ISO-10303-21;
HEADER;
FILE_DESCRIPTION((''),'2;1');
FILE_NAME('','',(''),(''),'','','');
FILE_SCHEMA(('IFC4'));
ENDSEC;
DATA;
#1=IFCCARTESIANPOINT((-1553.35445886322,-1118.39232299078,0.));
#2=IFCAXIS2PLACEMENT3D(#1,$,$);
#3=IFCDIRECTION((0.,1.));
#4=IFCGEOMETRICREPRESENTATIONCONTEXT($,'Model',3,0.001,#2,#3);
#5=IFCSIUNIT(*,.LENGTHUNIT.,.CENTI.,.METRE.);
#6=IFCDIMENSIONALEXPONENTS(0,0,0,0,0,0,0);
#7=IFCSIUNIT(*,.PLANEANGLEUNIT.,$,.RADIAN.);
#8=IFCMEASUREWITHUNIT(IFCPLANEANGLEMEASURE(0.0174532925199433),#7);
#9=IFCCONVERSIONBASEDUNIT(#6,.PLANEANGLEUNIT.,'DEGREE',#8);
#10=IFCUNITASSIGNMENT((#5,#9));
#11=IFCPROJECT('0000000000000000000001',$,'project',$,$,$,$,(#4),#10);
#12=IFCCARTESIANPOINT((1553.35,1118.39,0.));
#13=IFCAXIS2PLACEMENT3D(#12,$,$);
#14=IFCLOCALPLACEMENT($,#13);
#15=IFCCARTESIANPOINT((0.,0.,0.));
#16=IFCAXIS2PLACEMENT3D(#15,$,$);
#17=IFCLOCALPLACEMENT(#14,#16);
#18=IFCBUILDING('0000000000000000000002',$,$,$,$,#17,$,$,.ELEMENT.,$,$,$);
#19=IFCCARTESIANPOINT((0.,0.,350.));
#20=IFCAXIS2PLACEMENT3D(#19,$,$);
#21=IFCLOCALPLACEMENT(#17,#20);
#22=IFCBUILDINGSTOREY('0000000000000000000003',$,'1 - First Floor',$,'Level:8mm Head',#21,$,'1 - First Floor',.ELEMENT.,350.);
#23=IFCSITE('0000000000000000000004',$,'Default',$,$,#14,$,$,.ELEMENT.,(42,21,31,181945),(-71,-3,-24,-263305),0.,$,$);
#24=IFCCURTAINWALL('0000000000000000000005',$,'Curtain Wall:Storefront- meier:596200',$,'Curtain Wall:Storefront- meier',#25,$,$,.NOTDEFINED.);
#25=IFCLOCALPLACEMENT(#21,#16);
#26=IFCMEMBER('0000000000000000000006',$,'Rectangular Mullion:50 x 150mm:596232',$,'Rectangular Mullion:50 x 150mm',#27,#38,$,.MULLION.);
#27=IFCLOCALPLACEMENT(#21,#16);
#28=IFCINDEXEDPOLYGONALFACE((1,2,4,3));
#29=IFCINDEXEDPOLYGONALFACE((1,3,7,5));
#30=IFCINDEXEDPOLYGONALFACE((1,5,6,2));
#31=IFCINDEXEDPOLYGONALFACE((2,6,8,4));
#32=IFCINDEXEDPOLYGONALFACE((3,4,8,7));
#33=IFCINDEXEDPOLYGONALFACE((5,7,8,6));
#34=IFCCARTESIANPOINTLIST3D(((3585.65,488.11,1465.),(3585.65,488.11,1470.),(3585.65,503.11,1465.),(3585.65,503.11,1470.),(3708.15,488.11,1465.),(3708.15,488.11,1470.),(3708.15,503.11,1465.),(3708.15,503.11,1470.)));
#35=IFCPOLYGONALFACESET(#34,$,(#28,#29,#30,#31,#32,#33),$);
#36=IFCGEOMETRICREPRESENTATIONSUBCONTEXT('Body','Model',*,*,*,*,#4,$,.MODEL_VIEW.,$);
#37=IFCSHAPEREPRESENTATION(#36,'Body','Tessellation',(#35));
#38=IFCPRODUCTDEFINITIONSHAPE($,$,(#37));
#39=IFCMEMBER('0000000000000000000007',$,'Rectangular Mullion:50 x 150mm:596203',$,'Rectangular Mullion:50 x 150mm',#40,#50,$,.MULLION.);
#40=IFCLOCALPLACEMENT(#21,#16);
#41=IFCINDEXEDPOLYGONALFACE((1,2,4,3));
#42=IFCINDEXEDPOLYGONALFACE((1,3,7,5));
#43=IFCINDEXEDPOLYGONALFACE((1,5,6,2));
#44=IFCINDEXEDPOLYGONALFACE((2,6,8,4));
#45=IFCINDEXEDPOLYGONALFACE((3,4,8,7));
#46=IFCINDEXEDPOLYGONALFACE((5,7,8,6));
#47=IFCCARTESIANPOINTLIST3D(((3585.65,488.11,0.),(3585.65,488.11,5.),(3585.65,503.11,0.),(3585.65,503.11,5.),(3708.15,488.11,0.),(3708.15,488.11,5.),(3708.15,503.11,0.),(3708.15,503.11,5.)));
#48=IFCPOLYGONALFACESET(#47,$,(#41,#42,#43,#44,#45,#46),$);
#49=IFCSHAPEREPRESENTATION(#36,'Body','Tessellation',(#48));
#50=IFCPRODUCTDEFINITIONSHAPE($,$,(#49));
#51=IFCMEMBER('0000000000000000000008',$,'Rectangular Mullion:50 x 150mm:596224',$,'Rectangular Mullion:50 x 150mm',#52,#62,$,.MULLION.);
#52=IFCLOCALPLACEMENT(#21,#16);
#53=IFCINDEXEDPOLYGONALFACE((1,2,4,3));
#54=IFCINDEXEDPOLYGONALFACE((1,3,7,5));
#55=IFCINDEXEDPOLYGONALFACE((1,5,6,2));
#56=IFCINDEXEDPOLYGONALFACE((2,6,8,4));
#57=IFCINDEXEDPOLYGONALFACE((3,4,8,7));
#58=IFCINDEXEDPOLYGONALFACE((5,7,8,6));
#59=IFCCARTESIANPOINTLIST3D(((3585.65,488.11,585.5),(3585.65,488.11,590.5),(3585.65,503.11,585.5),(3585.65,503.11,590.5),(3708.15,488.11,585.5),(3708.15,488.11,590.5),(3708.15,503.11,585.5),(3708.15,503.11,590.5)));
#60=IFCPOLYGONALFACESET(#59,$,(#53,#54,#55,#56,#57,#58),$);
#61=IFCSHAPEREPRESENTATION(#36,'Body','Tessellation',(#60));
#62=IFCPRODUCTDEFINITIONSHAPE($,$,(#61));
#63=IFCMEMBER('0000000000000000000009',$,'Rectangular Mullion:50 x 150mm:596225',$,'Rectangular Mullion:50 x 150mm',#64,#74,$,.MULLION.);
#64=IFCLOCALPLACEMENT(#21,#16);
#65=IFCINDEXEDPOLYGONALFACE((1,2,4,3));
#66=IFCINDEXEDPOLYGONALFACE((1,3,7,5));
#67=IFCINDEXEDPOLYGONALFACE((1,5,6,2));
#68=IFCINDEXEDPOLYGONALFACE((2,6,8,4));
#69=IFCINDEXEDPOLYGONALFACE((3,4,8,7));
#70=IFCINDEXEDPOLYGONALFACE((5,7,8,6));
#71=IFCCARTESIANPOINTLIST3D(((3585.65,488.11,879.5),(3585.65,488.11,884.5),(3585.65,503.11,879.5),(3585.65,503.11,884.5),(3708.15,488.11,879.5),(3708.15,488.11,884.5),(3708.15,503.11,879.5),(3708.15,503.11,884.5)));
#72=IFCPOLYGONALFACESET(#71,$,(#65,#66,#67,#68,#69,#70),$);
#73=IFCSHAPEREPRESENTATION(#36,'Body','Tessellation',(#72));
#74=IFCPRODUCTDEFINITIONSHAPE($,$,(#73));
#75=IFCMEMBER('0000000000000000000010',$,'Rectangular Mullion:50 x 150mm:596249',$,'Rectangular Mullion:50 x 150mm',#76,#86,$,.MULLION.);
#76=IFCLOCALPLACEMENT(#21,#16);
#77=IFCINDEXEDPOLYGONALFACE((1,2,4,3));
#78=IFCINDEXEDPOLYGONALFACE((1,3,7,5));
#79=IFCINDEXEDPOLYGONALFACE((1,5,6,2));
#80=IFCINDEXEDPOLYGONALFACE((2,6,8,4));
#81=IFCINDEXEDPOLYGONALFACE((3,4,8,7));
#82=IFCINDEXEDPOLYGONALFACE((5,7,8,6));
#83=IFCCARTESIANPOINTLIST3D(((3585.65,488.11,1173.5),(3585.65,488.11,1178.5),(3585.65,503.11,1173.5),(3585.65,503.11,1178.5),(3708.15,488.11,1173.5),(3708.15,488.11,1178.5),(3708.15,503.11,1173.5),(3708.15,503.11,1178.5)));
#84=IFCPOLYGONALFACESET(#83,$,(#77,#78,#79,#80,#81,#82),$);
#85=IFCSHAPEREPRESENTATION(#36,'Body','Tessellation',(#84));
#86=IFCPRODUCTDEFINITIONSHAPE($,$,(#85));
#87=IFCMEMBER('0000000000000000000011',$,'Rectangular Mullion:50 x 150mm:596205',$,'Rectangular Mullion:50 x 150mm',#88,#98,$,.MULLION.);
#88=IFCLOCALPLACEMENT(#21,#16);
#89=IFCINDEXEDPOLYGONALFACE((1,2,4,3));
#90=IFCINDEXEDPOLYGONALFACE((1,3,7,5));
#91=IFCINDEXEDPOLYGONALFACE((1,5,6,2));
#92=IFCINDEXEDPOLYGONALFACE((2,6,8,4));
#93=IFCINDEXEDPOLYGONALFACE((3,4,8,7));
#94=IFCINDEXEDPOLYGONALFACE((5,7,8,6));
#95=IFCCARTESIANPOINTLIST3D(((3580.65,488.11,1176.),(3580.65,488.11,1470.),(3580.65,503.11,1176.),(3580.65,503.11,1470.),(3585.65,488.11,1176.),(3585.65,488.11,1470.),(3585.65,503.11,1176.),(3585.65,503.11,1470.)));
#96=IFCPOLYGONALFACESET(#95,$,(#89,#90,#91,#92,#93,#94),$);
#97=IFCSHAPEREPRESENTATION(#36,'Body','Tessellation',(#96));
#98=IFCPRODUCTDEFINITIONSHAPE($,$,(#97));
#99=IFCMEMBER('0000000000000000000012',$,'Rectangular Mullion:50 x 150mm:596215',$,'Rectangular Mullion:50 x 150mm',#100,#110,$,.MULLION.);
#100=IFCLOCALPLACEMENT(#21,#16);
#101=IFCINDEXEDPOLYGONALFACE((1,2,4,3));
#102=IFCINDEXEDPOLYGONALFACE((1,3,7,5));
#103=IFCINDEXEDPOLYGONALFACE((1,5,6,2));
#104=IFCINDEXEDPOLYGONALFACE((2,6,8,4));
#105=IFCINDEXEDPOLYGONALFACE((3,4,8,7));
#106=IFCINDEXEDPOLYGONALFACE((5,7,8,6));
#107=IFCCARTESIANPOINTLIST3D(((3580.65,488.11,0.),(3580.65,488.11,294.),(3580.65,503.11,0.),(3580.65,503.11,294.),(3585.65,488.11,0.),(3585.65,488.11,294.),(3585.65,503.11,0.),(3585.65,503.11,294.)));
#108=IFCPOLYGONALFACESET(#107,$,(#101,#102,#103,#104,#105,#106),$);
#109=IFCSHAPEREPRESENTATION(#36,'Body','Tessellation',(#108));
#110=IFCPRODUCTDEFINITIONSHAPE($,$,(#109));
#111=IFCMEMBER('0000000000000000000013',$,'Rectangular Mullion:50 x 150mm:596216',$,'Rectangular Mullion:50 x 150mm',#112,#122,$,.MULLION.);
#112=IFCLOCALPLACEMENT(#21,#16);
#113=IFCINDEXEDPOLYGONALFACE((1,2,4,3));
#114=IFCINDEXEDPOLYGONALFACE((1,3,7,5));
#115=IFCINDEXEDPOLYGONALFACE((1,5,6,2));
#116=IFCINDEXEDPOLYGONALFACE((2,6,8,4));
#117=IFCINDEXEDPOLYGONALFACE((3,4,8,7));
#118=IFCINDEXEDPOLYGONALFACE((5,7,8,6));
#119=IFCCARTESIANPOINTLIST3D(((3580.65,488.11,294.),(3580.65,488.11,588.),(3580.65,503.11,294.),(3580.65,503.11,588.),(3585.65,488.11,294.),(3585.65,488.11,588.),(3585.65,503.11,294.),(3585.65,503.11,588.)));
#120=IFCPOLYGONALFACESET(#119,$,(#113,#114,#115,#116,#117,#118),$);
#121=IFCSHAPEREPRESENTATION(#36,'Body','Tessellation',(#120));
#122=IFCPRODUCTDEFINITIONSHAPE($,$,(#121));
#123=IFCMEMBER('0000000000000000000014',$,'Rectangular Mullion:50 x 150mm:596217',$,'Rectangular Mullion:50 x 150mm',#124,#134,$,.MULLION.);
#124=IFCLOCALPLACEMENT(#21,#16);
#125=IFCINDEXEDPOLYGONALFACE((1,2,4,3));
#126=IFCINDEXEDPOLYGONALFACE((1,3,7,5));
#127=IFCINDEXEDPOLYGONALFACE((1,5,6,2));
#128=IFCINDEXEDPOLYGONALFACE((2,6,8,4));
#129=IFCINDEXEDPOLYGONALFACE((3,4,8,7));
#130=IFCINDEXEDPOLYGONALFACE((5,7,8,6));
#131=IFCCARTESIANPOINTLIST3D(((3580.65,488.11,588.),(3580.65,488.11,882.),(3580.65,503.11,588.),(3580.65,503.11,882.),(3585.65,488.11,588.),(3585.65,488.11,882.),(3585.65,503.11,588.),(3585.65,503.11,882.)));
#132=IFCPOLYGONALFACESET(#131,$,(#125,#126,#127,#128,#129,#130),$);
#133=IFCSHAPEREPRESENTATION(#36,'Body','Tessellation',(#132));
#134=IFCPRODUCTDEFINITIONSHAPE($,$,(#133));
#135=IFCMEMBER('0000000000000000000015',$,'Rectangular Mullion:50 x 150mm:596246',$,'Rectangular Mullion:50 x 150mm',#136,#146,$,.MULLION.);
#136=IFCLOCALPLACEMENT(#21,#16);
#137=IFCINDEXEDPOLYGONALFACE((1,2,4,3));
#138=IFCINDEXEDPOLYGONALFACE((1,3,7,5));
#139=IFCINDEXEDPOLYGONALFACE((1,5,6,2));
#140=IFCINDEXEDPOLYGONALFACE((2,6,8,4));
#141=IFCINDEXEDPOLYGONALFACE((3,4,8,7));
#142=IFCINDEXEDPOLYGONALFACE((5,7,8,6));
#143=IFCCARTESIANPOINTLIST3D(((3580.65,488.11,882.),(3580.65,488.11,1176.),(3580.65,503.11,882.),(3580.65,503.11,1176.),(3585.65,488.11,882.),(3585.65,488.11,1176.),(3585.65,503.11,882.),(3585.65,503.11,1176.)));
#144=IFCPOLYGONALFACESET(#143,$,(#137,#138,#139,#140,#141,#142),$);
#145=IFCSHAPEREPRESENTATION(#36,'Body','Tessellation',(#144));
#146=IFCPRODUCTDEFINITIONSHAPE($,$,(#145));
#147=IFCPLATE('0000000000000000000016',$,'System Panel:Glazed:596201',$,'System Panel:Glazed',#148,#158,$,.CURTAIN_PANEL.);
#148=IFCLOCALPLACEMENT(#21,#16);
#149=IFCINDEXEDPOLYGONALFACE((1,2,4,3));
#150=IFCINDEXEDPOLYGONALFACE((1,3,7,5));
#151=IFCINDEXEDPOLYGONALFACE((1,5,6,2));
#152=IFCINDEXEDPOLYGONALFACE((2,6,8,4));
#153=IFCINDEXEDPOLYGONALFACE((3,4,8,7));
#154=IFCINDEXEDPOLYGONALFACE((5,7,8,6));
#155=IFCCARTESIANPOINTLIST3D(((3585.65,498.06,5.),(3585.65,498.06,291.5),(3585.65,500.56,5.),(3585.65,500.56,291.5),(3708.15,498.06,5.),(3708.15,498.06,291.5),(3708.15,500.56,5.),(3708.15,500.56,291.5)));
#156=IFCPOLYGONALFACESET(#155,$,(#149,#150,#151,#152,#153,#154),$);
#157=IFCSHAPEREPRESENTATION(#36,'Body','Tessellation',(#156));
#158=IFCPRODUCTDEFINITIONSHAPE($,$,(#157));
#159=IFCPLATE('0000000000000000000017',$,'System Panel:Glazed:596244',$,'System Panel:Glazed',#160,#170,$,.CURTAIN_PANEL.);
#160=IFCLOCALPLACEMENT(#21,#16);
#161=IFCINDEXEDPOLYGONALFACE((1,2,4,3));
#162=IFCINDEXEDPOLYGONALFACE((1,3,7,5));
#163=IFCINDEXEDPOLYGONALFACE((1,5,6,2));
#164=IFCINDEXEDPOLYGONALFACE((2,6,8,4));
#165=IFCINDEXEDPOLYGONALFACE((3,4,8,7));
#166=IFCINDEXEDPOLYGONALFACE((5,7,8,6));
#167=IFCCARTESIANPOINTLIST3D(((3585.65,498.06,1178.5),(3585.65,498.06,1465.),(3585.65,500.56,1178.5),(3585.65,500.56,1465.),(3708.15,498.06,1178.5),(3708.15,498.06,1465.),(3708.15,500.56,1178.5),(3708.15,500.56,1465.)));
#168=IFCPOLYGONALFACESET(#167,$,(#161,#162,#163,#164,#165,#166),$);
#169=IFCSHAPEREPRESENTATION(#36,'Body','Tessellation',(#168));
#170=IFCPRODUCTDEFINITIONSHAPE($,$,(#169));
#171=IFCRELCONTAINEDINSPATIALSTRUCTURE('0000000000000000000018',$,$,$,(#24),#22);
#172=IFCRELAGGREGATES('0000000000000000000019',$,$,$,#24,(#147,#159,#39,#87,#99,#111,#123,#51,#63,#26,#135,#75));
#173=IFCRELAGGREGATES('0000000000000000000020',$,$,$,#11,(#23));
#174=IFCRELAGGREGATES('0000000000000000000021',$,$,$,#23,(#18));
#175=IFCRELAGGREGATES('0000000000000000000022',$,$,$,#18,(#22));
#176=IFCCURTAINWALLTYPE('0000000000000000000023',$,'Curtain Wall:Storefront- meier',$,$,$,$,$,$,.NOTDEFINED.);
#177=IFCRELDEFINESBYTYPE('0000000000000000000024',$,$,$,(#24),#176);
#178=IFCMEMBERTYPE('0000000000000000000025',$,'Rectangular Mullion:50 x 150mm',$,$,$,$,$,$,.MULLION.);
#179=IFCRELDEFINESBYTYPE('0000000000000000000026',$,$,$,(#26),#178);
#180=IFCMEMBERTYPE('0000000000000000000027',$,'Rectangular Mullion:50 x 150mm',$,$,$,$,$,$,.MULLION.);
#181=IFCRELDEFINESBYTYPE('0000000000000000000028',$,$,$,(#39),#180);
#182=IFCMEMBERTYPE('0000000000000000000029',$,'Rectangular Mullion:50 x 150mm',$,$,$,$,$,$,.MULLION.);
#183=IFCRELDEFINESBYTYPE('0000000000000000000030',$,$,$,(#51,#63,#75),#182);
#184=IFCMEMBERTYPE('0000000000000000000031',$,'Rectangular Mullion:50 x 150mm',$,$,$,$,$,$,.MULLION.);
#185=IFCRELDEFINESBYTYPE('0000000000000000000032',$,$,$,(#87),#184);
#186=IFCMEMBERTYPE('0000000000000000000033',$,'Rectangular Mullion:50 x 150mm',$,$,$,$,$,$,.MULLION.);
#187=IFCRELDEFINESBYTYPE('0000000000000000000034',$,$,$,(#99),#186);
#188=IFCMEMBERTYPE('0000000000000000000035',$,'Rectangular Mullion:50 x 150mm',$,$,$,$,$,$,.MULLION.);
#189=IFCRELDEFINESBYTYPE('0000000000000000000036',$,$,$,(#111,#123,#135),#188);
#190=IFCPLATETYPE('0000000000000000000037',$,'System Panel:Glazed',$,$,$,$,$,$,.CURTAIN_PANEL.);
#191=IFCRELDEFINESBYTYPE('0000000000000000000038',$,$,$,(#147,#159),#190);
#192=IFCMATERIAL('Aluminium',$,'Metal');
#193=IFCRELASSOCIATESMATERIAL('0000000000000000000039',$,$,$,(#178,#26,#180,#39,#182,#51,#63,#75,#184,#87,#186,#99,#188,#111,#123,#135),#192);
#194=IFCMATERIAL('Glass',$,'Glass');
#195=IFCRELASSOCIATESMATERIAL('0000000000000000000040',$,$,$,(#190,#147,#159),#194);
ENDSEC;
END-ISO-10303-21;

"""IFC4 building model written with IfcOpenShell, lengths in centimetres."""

from ifc_helpers import new_model, entity, si_unit, converted_unit, direction, frame, origin, place, context, subcontext, project, spatial, indexed_curve, outline, extrude, source, transform, mapped, material, type_object, type_shapes, element, aggregate, save


model = new_model("IFC4")

# Units and contexts
model_context = context("Model", 3, precision=0.001, world=frame((-1553.35445886322, -1118.39232299078, 0.0)), true_north=direction((0.0, 1.0)))
body_context = subcontext(model_context, "Body", "Model", "MODEL_VIEW")
ifc_project = project(units=[si_unit("LENGTHUNIT", "METRE", prefix="CENTI"), converted_unit("PLANEANGLEUNIT", "DEGREE", entity("IfcPlaneAngleMeasure", 0.0174532925199433), si_unit("PLANEANGLEUNIT", "RADIAN"), dimensions=[0, 0, 0, 0, 0, 0, 0])], contexts=[model_context])

# Site, building, storey
site_placement = place(None, frame((1553.35, 1118.39, 0.0)))
site = spatial("IfcSite", under=ifc_project, at=site_placement, Name="Default", CompositionType="ELEMENT", RefLatitude=(42, 21, 31, 181945), RefLongitude=(-71, -3, -24, -263305), RefElevation=0.0)
building_placement = place(site_placement, origin())
building = spatial("IfcBuilding", under=site, at=building_placement, CompositionType="ELEMENT")
storey_placement = place(building_placement, frame((0.0, 0.0, 350.0)))
storey = spatial("IfcBuildingStorey", under=building, at=storey_placement, Name="1 - First Floor", ObjectType="Level:8mm Head", LongName="1 - First Floor", CompositionType="ELEMENT", Elevation=350.0)

# Curtain wall, members, plates
curtain_wall_type = type_object("IfcCurtainWallType", Name="Curtain Wall:Storefront- meier", PredefinedType="NOTDEFINED")
curtain_wall_placement = place(storey_placement, frame((0.0, 0.0, -350.0)))
curtain_wall = element("IfcCurtainWall", 1, at=curtain_wall_placement, inside=storey, type_object=curtain_wall_type, Name="Curtain Wall:Storefront- meier:596200", ObjectType="Curtain Wall:Storefront- meier", PredefinedType="NOTDEFINED")
ifc_material_1 = material(Name="Aluminium", Category="Metal")
member_type_1 = type_object("IfcMemberType", Name="Rectangular Mullion:50 x 150mm", PredefinedType="MULLION", material=ifc_material_1)
shared_shape_1 = source(origin(), body_context, "Body", "SweptSolid", [
    extrude(outline(indexed_curve([(-2.5, -7.5), (2.5, -7.5), (2.5, 7.5), (-2.5, 7.5), (-2.5, -7.5)], self_intersect=False)), frame((-2.5, 0.0, -122.5), z_axis=(0.0, 0.0, 1.0), x_axis=(-1.0, 0.0, 0.0)), (0.0, 0.0, 1.0), 122.5),
])
type_shapes(member_type_1, [shared_shape_1])
member_1_placement = place(curtain_wall_placement, frame((3708.15, 495.61, 1820.0), z_axis=(1.0, 0.0, 0.0), x_axis=(0.0, 0.0, 1.0)))
member_1 = element("IfcMember", 2, at=member_1_placement, type_object=member_type_1, material=ifc_material_1, Name="Rectangular Mullion:50 x 150mm:596232", ObjectType="Rectangular Mullion:50 x 150mm", PredefinedType="MULLION", context=body_context, shape_type="MappedRepresentation", body=[
    mapped(shared_shape_1, transform((0.0, 0.0, 0.0), scale=1.0)),
])
member_type_2 = type_object("IfcMemberType", Name="Rectangular Mullion:50 x 150mm", PredefinedType="MULLION", material=ifc_material_1)
shared_shape_2 = source(origin(), body_context, "Body", "SweptSolid", [
    extrude(outline(indexed_curve([(-2.5, -7.5), (2.5, -7.5), (2.5, 7.5), (-2.5, 7.5), (-2.5, -7.5)], self_intersect=False)), frame((-2.5, 0.0, -122.5), z_axis=(0.0, 0.0, 1.0), x_axis=(-1.0, 0.0, 0.0)), (0.0, 0.0, 1.0), 122.5),
])
type_shapes(member_type_2, [shared_shape_2])
member_2_placement = place(curtain_wall_placement, frame((3585.65, 495.61, 350.0), z_axis=(-1.0, 0.0, 0.0), x_axis=(0.0, 0.0, -1.0)))
member_2 = element("IfcMember", 3, at=member_2_placement, type_object=member_type_2, material=ifc_material_1, Name="Rectangular Mullion:50 x 150mm:596203", ObjectType="Rectangular Mullion:50 x 150mm", PredefinedType="MULLION", context=body_context, shape_type="MappedRepresentation", body=[
    mapped(shared_shape_2, transform((0.0, 0.0, 0.0), scale=1.0)),
])
member_type_3 = type_object("IfcMemberType", Name="Rectangular Mullion:50 x 150mm", PredefinedType="MULLION", material=ifc_material_1)
shared_shape_3 = source(origin(), body_context, "Body", "SweptSolid", [
    extrude(outline(indexed_curve([(-2.5, -7.5), (2.5, -7.5), (2.5, 7.5), (-2.5, 7.5), (-2.5, -7.5)], self_intersect=False)), frame((0.0, 0.0, -122.5), z_axis=(0.0, 0.0, 1.0), x_axis=(-1.0, 0.0, 0.0)), (0.0, 0.0, 1.0), 122.5),
])
type_shapes(member_type_3, [shared_shape_3])
member_3_placement = place(curtain_wall_placement, frame((3708.15, 495.61, 938.0), z_axis=(1.0, 0.0, 0.0), x_axis=(0.0, 0.0, 1.0)))
member_3 = element("IfcMember", 4, at=member_3_placement, type_object=member_type_3, material=ifc_material_1, Name="Rectangular Mullion:50 x 150mm:596224", ObjectType="Rectangular Mullion:50 x 150mm", PredefinedType="MULLION", context=body_context, shape_type="MappedRepresentation", body=[
    mapped(shared_shape_3, transform((0.0, 0.0, 0.0), scale=1.0)),
])
member_4_placement = place(curtain_wall_placement, frame((3708.15, 495.61, 1232.0), z_axis=(1.0, 0.0, 0.0), x_axis=(0.0, 0.0, 1.0)))
member_4 = element("IfcMember", 5, at=member_4_placement, type_object=member_type_3, material=ifc_material_1, Name="Rectangular Mullion:50 x 150mm:596225", ObjectType="Rectangular Mullion:50 x 150mm", PredefinedType="MULLION", context=body_context, shape_type="MappedRepresentation", body=[
    mapped(shared_shape_3, transform((0.0, 0.0, 0.0), scale=1.0)),
])
member_5_placement = place(curtain_wall_placement, frame((3708.15, 495.61, 1526.0), z_axis=(1.0, 0.0, 0.0), x_axis=(0.0, 0.0, 1.0)))
member_5 = element("IfcMember", 6, at=member_5_placement, type_object=member_type_3, material=ifc_material_1, Name="Rectangular Mullion:50 x 150mm:596249", ObjectType="Rectangular Mullion:50 x 150mm", PredefinedType="MULLION", context=body_context, shape_type="MappedRepresentation", body=[
    mapped(shared_shape_3, transform((0.0, 0.0, 0.0), scale=1.0)),
])
member_type_4 = type_object("IfcMemberType", Name="Rectangular Mullion:50 x 150mm", PredefinedType="MULLION", material=ifc_material_1)
shared_shape_4 = source(origin(), body_context, "Body", "SweptSolid", [
    extrude(outline(indexed_curve([(-2.5, -7.5), (2.5, -7.5), (2.5, 7.5), (-2.5, 7.5), (-2.5, -7.5)], self_intersect=False)), frame((-2.5, 0.0, -294.0), z_axis=(0.0, 0.0, 1.0), x_axis=(-1.0, 0.0, 0.0)), (0.0, 0.0, 1.0), 294.0),
])
type_shapes(member_type_4, [shared_shape_4])
member_6_placement = place(curtain_wall_placement, frame((3580.65, 495.61, 1820.0), z_axis=(0.0, 0.0, 1.0), x_axis=(-1.0, 0.0, 0.0)))
member_6 = element("IfcMember", 7, at=member_6_placement, type_object=member_type_4, material=ifc_material_1, Name="Rectangular Mullion:50 x 150mm:596205", ObjectType="Rectangular Mullion:50 x 150mm", PredefinedType="MULLION", context=body_context, shape_type="MappedRepresentation", body=[
    mapped(shared_shape_4, transform((0.0, 0.0, 0.0), scale=1.0)),
])
member_type_5 = type_object("IfcMemberType", Name="Rectangular Mullion:50 x 150mm", PredefinedType="MULLION", material=ifc_material_1)
shared_shape_5 = source(origin(), body_context, "Body", "SweptSolid", [
    extrude(outline(indexed_curve([(-2.5, -7.5), (2.5, -7.5), (2.5, 7.5), (-2.5, 7.5), (-2.5, -7.5)], self_intersect=False)), frame((-2.5, 0.0, -294.0), z_axis=(0.0, 0.0, 1.0), x_axis=(-1.0, 0.0, 0.0)), (0.0, 0.0, 1.0), 294.0),
])
type_shapes(member_type_5, [shared_shape_5])
member_7_placement = place(curtain_wall_placement, frame((3580.65, 495.61, 644.0), z_axis=(0.0, 0.0, 1.0), x_axis=(-1.0, 0.0, 0.0)))
member_7 = element("IfcMember", 8, at=member_7_placement, type_object=member_type_5, material=ifc_material_1, Name="Rectangular Mullion:50 x 150mm:596215", ObjectType="Rectangular Mullion:50 x 150mm", PredefinedType="MULLION", context=body_context, shape_type="MappedRepresentation", body=[
    mapped(shared_shape_5, transform((0.0, 0.0, 0.0), scale=1.0)),
])
member_type_6 = type_object("IfcMemberType", Name="Rectangular Mullion:50 x 150mm", PredefinedType="MULLION", material=ifc_material_1)
shared_shape_6 = source(origin(), body_context, "Body", "SweptSolid", [
    extrude(outline(indexed_curve([(-2.5, -7.5), (2.5, -7.5), (2.5, 7.5), (-2.5, 7.5), (-2.5, -7.5)], self_intersect=False)), frame((-2.5, 0.0, -294.0), z_axis=(0.0, 0.0, 1.0), x_axis=(-1.0, 0.0, 0.0)), (0.0, 0.0, 1.0), 294.0),
])
type_shapes(member_type_6, [shared_shape_6])
member_8_placement = place(curtain_wall_placement, frame((3580.65, 495.61, 938.0), z_axis=(0.0, 0.0, 1.0), x_axis=(-1.0, 0.0, 0.0)))
member_8 = element("IfcMember", 9, at=member_8_placement, type_object=member_type_6, material=ifc_material_1, Name="Rectangular Mullion:50 x 150mm:596216", ObjectType="Rectangular Mullion:50 x 150mm", PredefinedType="MULLION", context=body_context, shape_type="MappedRepresentation", body=[
    mapped(shared_shape_6, transform((0.0, 0.0, 0.0), scale=1.0)),
])
member_9_placement = place(curtain_wall_placement, frame((3580.65, 495.61, 1232.0), z_axis=(0.0, 0.0, 1.0), x_axis=(-1.0, 0.0, 0.0)))
member_9 = element("IfcMember", 10, at=member_9_placement, type_object=member_type_6, material=ifc_material_1, Name="Rectangular Mullion:50 x 150mm:596217", ObjectType="Rectangular Mullion:50 x 150mm", PredefinedType="MULLION", context=body_context, shape_type="MappedRepresentation", body=[
    mapped(shared_shape_6, transform((0.0, 0.0, 0.0), scale=1.0)),
])
member_10_placement = place(curtain_wall_placement, frame((3580.65, 495.61, 1526.0), z_axis=(0.0, 0.0, 1.0), x_axis=(-1.0, 0.0, 0.0)))
member_10 = element("IfcMember", 11, at=member_10_placement, type_object=member_type_6, material=ifc_material_1, Name="Rectangular Mullion:50 x 150mm:596246", ObjectType="Rectangular Mullion:50 x 150mm", PredefinedType="MULLION", context=body_context, shape_type="MappedRepresentation", body=[
    mapped(shared_shape_6, transform((0.0, 0.0, 0.0), scale=1.0)),
])
ifc_material_2 = material(Name="Glass", Category="Glass")
plate_type_1 = type_object("IfcPlateType", Name="System Panel:Glazed", PredefinedType="CURTAIN_PANEL", material=ifc_material_2)
shared_shape_7 = source(origin(), body_context, "Body", "SweptSolid", [
    extrude(outline(indexed_curve([(-1.25, -61.25), (1.25, -61.25), (1.25, 61.25), (-1.25, 61.25), (-1.25, -61.25)], self_intersect=False)), frame((0.0, 3.7, 0.0), z_axis=(0.0, 0.0, 1.0), x_axis=(0.0, 1.0, 0.0)), (0.0, 0.0, 1.0), 286.5),
])
type_shapes(plate_type_1, [shared_shape_7])
plate_1_placement = place(curtain_wall_placement, frame((3646.9, 495.61, 355.0)))
plate_1 = element("IfcPlate", 12, at=plate_1_placement, type_object=plate_type_1, material=ifc_material_2, Name="System Panel:Glazed:596201", ObjectType="System Panel:Glazed", PredefinedType="CURTAIN_PANEL", context=body_context, shape_type="MappedRepresentation", body=[
    mapped(shared_shape_7, transform((0.0, 0.0, 0.0), scale=1.0)),
])
plate_2_placement = place(curtain_wall_placement, frame((3646.9, 495.61, 1528.5)))
plate_2 = element("IfcPlate", 13, at=plate_2_placement, type_object=plate_type_1, material=ifc_material_2, Name="System Panel:Glazed:596244", ObjectType="System Panel:Glazed", PredefinedType="CURTAIN_PANEL", context=body_context, shape_type="MappedRepresentation", body=[
    mapped(shared_shape_7, transform((0.0, 0.0, 0.0), scale=1.0)),
])
aggregate(curtain_wall, [plate_1, plate_2, member_2, member_6, member_7, member_8, member_9, member_3, member_4, member_1, member_10, member_5])

save(model, "model.ifc")
